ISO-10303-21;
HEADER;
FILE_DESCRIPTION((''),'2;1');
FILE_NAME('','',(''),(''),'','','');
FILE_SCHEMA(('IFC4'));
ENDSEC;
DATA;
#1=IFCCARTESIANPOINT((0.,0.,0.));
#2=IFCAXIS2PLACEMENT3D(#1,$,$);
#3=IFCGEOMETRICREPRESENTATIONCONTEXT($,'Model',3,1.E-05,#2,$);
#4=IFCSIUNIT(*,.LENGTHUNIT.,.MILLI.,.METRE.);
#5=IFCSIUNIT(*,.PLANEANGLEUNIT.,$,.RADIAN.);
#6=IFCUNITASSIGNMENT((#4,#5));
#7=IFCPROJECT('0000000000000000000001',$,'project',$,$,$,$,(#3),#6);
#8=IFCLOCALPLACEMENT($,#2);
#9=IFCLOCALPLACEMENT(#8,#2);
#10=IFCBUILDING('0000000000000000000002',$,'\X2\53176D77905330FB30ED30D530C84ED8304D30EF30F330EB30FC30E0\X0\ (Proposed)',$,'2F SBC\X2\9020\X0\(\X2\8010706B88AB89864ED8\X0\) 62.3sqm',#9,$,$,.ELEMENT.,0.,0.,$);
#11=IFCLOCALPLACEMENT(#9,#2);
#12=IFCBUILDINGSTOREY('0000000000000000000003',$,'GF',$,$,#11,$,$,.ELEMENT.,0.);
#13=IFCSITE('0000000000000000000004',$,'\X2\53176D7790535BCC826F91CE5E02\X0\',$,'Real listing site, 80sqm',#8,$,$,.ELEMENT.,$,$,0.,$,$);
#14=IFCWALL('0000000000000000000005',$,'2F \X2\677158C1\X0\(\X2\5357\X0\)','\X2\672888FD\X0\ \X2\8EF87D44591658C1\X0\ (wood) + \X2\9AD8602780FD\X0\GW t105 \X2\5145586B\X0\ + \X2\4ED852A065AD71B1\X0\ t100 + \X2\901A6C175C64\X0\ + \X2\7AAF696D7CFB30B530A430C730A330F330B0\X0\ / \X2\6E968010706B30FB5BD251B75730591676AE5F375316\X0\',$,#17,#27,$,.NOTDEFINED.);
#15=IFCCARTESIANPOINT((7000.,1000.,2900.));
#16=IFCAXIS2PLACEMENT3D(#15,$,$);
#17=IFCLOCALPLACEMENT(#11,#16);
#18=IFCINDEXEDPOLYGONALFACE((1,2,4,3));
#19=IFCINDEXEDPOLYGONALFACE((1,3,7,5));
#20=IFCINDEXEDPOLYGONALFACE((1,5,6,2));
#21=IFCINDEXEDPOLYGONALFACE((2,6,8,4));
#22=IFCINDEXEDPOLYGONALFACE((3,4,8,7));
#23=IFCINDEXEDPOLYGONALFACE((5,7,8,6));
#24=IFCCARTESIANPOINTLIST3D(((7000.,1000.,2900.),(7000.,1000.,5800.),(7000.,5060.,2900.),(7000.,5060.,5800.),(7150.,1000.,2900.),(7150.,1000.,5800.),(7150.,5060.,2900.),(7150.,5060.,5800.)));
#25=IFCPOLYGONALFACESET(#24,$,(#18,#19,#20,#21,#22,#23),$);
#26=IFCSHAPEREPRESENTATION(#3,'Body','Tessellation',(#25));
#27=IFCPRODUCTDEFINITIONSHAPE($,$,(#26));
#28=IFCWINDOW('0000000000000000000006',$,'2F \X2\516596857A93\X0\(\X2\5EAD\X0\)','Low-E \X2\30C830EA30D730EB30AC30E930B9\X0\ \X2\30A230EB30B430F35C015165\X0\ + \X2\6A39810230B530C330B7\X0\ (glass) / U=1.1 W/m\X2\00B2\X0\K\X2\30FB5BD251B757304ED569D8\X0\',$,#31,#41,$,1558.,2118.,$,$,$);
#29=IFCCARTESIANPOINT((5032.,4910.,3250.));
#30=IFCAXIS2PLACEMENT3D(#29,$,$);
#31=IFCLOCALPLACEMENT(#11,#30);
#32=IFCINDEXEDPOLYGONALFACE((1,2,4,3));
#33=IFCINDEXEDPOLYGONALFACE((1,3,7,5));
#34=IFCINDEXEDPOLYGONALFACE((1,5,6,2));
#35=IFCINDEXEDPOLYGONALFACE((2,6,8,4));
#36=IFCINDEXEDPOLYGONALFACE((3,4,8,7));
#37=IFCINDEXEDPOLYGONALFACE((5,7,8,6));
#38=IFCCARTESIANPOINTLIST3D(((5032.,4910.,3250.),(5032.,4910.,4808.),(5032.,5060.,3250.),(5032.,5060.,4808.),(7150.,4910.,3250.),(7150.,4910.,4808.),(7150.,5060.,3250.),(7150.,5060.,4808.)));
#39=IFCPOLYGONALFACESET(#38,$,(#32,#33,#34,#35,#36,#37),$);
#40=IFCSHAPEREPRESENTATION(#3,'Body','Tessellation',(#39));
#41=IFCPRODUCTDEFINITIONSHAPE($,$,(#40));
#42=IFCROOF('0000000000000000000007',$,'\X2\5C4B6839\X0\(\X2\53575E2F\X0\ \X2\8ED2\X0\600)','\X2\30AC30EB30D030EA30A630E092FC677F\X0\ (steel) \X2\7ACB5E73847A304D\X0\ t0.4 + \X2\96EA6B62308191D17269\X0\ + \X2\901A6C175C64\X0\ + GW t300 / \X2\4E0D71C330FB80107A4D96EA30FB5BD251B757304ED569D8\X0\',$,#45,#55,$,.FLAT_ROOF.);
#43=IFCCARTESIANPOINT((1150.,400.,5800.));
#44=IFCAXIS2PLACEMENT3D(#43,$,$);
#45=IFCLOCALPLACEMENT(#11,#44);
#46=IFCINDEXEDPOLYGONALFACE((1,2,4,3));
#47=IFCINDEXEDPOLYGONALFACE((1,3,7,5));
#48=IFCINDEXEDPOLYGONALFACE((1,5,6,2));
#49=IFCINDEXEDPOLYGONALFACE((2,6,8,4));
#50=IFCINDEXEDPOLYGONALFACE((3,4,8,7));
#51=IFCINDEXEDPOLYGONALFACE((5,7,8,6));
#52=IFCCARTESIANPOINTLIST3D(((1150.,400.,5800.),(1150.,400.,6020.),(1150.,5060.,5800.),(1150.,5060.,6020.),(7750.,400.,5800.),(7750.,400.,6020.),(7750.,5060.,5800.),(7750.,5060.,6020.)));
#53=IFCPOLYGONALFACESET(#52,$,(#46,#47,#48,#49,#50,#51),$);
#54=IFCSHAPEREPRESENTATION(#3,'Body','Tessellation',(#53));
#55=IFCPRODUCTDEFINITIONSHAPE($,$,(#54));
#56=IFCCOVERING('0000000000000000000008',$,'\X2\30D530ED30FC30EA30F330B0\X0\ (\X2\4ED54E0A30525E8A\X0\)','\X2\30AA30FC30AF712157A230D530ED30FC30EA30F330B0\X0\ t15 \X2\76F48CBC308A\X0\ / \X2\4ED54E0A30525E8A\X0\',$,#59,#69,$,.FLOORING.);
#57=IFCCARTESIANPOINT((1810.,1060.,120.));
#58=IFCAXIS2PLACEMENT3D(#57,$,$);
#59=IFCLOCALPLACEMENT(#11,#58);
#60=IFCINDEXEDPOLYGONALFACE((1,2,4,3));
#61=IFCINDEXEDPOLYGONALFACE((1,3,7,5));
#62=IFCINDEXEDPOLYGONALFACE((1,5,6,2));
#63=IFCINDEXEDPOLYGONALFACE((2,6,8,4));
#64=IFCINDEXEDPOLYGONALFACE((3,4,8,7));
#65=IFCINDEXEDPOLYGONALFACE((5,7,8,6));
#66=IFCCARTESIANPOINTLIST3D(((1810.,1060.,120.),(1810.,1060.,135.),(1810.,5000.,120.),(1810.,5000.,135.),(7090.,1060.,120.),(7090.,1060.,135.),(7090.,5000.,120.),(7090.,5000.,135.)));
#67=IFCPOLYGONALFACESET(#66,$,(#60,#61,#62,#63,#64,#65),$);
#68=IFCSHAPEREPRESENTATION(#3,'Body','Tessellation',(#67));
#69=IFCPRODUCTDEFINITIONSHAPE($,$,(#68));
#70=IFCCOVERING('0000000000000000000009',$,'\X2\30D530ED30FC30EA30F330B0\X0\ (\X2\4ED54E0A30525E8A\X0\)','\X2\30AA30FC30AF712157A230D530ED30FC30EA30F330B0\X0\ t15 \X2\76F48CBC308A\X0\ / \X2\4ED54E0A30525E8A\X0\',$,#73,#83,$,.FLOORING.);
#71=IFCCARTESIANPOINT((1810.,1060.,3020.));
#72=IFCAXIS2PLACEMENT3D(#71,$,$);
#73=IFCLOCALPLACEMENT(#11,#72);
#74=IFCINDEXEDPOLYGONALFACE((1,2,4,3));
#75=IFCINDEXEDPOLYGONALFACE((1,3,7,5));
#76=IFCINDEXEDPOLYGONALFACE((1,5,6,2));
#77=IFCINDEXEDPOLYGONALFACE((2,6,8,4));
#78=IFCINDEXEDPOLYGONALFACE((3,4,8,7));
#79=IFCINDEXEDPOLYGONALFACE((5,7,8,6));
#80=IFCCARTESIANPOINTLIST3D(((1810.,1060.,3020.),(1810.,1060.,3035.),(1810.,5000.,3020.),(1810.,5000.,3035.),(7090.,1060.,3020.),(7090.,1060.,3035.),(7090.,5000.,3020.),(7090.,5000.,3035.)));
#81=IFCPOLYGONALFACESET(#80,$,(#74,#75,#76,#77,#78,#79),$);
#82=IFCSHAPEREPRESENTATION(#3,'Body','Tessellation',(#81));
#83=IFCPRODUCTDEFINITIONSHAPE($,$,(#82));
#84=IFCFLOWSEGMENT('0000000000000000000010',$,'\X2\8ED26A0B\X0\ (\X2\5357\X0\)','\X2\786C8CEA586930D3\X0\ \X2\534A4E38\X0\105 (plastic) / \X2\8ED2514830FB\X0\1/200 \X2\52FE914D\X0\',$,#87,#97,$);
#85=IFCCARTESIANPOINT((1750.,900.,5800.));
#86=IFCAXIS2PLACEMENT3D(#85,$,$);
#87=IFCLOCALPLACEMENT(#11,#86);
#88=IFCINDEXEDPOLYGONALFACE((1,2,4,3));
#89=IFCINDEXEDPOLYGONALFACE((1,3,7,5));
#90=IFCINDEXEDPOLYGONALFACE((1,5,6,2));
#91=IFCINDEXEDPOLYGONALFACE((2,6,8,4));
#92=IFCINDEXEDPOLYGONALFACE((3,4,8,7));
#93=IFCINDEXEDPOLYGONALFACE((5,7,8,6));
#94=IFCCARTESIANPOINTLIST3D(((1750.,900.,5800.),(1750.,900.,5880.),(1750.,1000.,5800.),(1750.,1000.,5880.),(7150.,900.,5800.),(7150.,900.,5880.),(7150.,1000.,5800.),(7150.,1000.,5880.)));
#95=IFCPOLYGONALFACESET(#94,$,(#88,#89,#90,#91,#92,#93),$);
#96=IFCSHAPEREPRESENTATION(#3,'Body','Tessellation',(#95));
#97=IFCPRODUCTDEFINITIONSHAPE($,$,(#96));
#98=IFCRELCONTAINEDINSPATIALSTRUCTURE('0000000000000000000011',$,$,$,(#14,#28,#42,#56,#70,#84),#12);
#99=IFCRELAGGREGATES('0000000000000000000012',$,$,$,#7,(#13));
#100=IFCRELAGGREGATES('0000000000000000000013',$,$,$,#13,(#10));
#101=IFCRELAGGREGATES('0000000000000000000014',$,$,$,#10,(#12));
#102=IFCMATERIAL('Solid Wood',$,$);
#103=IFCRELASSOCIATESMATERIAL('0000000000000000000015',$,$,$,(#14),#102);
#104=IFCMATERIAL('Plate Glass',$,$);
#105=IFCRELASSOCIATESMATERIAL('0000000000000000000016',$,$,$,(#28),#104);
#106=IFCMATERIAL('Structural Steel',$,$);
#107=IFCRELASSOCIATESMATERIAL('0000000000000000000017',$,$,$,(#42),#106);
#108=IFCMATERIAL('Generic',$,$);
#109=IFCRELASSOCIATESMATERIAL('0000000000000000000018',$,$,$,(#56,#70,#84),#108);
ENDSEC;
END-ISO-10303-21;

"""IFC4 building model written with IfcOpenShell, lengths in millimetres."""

from ifc_helpers import new_model, si_unit, frame, frame_2d, origin, place, context, project, spatial, rectangle, extrude, material, element, fill, save


model = new_model("IFC4")

# Units and contexts
model_context = context("Model", 3, precision=1e-05, world=origin())
ifc_project = project(units=[si_unit("LENGTHUNIT", "METRE", prefix="MILLI"), si_unit("PLANEANGLEUNIT", "RADIAN")], contexts=[model_context])

# Site, building, storey
site_placement = place(None, origin())
site = spatial("IfcSite", under=ifc_project, at=site_placement, Name="北海道富良野市", ObjectType="Real listing site, 80sqm", CompositionType="ELEMENT", RefElevation=0.0)
building_placement = place(site_placement, origin())
building = spatial("IfcBuilding", under=site, at=building_placement, Name="北海道・ロフト付きワンルーム (Proposed)", ObjectType="2F SBC造(耐火被覆付) 62.3sqm", CompositionType="ELEMENT", ElevationOfRefHeight=0.0, ElevationOfTerrain=0.0)
storey_placement = place(building_placement, origin())
storey = spatial("IfcBuildingStorey", under=building, at=storey_placement, Name="GF", CompositionType="ELEMENT", Elevation=0.0)

# Shared definitions
ifc_material_1 = material(Name="Solid Wood")

# Wall, opening, window
ifc_material_2 = material(Name="Plate Glass")
wall_1_placement = place(storey_placement, frame((7000.0, 1000.0, 2900.0)))
wall_1 = element("IfcWall", 1, at=wall_1_placement, inside=storey, material=ifc_material_1, Name="2F 東壁(南)", Description="木製 軸組外壁 (wood) + 高性能GW t105 充填 + 付加断熱 t100 + 通気層 + 窯業系サイディング / 準耐火・寒冷地外皮強化", PredefinedType="NOTDEFINED", context=model_context, shape_type="SweptSolid", body=[
    extrude(rectangle(XDim=150.0, YDim=4060.0, at=frame_2d((75.0, 2030.0))), frame((7000.0, 1000.0, 2900.0)), (0.0, 0.0, 1.0), 2900.0),
])
opening_1_placement = place(storey_placement, frame((5032.0, 4910.0, 3250.0)))
opening_1 = element("IfcOpeningElement", 2, at=opening_1_placement, cuts=wall_1, PredefinedType="NOTDEFINED", context=model_context, shape_type="SweptSolid", body=[
    extrude(rectangle(XDim=2118.0, YDim=150.0, at=frame_2d((1059.0, 75.0))), frame((5032.0, 4910.0, 3250.0)), (0.0, 0.0, 1.0), 1558.0),
])
window_1_placement = place(storey_placement, frame((5032.0, 4910.0, 3250.0)))
window_1 = element("IfcWindow", 3, at=window_1_placement, inside=storey, material=ifc_material_2, Name="2F 入隅窓(庭)", Description="Low-E トリプルガラス アルゴン封入 + 樹脂サッシ (glass) / U=1.1 W/m²K・寒冷地仕様", OverallHeight=1558.0, OverallWidth=2118.0, context=model_context, shape_type="SweptSolid", body=[
    extrude(rectangle(XDim=2118.0, YDim=150.0, at=frame_2d((1059.0, 75.0))), frame((5032.0, 4910.0, 3250.0)), (0.0, 0.0, 1.0), 1558.0),
])
fill(opening_1, window_1)

# Roof
ifc_material_3 = material(Name="Structural Steel")
for number, where, name in (
    (4, (1150.0, 400.0, 5800.0), "屋根(南帯 軒600)"),
):
    element("IfcRoof", number, at=place(storey_placement, frame(where)), inside=storey, material=ifc_material_3, Name=name, Description="ガルバリウム鋼板 (steel) 立平葺き t0.4 + 雪止め金物 + 通気層 + GW t300 / 不燃・耐積雪・寒冷地仕様", PredefinedType="FLAT_ROOF", context=model_context, shape_type="SweptSolid", body=[
        extrude(rectangle(XDim=6600.0, YDim=4660.0, at=frame_2d((3300.0, 2330.0))), frame((1150.0, 400.0, 5800.0)), (0.0, 0.0, 1.0), 220.0),
    ])

# Coverings
ifc_material_4 = material(Name="Generic")
covering_1_placement = place(storey_placement, frame((1810.0, 1060.0, 120.0)))
element("IfcCovering", 5, at=covering_1_placement, inside=storey, material=ifc_material_4, Name="フローリング (仕上げ床)", Description="オーク無垢フローリング t15 直貼り / 仕上げ床", PredefinedType="FLOORING", context=model_context, shape_type="SweptSolid", body=[
    extrude(rectangle(XDim=5280.0, YDim=3940.0, at=frame_2d((2640.0, 1970.0))), frame((1810.0, 1060.0, 120.0)), (0.0, 0.0, 1.0), 15.0),
])
covering_2_placement = place(storey_placement, frame((1810.0, 1060.0, 3020.0)))
element("IfcCovering", 6, at=covering_2_placement, inside=storey, material=ifc_material_4, Name="フローリング (仕上げ床)", Description="オーク無垢フローリング t15 直貼り / 仕上げ床", PredefinedType="FLOORING", context=model_context, shape_type="SweptSolid", body=[
    extrude(rectangle(XDim=5280.0, YDim=3940.0, at=frame_2d((2640.0, 1970.0))), frame((1810.0, 1060.0, 3020.0)), (0.0, 0.0, 1.0), 15.0),
])

# Flow segment
flow_segment_placement = place(storey_placement, frame((1750.0, 900.0, 5800.0)))
element("IfcFlowSegment", 7, at=flow_segment_placement, inside=storey, material=ifc_material_4, Name="軒樋 (南)", Description="硬質塩ビ 半丸105 (plastic) / 軒先・1/200 勾配", context=model_context, shape_type="SweptSolid", body=[
    extrude(rectangle(XDim=5400.0, YDim=100.0, at=frame_2d((2700.0, 50.0))), frame((1750.0, 900.0, 5800.0)), (0.0, 0.0, 1.0), 80.0),
])

save(model, "model.ifc")
